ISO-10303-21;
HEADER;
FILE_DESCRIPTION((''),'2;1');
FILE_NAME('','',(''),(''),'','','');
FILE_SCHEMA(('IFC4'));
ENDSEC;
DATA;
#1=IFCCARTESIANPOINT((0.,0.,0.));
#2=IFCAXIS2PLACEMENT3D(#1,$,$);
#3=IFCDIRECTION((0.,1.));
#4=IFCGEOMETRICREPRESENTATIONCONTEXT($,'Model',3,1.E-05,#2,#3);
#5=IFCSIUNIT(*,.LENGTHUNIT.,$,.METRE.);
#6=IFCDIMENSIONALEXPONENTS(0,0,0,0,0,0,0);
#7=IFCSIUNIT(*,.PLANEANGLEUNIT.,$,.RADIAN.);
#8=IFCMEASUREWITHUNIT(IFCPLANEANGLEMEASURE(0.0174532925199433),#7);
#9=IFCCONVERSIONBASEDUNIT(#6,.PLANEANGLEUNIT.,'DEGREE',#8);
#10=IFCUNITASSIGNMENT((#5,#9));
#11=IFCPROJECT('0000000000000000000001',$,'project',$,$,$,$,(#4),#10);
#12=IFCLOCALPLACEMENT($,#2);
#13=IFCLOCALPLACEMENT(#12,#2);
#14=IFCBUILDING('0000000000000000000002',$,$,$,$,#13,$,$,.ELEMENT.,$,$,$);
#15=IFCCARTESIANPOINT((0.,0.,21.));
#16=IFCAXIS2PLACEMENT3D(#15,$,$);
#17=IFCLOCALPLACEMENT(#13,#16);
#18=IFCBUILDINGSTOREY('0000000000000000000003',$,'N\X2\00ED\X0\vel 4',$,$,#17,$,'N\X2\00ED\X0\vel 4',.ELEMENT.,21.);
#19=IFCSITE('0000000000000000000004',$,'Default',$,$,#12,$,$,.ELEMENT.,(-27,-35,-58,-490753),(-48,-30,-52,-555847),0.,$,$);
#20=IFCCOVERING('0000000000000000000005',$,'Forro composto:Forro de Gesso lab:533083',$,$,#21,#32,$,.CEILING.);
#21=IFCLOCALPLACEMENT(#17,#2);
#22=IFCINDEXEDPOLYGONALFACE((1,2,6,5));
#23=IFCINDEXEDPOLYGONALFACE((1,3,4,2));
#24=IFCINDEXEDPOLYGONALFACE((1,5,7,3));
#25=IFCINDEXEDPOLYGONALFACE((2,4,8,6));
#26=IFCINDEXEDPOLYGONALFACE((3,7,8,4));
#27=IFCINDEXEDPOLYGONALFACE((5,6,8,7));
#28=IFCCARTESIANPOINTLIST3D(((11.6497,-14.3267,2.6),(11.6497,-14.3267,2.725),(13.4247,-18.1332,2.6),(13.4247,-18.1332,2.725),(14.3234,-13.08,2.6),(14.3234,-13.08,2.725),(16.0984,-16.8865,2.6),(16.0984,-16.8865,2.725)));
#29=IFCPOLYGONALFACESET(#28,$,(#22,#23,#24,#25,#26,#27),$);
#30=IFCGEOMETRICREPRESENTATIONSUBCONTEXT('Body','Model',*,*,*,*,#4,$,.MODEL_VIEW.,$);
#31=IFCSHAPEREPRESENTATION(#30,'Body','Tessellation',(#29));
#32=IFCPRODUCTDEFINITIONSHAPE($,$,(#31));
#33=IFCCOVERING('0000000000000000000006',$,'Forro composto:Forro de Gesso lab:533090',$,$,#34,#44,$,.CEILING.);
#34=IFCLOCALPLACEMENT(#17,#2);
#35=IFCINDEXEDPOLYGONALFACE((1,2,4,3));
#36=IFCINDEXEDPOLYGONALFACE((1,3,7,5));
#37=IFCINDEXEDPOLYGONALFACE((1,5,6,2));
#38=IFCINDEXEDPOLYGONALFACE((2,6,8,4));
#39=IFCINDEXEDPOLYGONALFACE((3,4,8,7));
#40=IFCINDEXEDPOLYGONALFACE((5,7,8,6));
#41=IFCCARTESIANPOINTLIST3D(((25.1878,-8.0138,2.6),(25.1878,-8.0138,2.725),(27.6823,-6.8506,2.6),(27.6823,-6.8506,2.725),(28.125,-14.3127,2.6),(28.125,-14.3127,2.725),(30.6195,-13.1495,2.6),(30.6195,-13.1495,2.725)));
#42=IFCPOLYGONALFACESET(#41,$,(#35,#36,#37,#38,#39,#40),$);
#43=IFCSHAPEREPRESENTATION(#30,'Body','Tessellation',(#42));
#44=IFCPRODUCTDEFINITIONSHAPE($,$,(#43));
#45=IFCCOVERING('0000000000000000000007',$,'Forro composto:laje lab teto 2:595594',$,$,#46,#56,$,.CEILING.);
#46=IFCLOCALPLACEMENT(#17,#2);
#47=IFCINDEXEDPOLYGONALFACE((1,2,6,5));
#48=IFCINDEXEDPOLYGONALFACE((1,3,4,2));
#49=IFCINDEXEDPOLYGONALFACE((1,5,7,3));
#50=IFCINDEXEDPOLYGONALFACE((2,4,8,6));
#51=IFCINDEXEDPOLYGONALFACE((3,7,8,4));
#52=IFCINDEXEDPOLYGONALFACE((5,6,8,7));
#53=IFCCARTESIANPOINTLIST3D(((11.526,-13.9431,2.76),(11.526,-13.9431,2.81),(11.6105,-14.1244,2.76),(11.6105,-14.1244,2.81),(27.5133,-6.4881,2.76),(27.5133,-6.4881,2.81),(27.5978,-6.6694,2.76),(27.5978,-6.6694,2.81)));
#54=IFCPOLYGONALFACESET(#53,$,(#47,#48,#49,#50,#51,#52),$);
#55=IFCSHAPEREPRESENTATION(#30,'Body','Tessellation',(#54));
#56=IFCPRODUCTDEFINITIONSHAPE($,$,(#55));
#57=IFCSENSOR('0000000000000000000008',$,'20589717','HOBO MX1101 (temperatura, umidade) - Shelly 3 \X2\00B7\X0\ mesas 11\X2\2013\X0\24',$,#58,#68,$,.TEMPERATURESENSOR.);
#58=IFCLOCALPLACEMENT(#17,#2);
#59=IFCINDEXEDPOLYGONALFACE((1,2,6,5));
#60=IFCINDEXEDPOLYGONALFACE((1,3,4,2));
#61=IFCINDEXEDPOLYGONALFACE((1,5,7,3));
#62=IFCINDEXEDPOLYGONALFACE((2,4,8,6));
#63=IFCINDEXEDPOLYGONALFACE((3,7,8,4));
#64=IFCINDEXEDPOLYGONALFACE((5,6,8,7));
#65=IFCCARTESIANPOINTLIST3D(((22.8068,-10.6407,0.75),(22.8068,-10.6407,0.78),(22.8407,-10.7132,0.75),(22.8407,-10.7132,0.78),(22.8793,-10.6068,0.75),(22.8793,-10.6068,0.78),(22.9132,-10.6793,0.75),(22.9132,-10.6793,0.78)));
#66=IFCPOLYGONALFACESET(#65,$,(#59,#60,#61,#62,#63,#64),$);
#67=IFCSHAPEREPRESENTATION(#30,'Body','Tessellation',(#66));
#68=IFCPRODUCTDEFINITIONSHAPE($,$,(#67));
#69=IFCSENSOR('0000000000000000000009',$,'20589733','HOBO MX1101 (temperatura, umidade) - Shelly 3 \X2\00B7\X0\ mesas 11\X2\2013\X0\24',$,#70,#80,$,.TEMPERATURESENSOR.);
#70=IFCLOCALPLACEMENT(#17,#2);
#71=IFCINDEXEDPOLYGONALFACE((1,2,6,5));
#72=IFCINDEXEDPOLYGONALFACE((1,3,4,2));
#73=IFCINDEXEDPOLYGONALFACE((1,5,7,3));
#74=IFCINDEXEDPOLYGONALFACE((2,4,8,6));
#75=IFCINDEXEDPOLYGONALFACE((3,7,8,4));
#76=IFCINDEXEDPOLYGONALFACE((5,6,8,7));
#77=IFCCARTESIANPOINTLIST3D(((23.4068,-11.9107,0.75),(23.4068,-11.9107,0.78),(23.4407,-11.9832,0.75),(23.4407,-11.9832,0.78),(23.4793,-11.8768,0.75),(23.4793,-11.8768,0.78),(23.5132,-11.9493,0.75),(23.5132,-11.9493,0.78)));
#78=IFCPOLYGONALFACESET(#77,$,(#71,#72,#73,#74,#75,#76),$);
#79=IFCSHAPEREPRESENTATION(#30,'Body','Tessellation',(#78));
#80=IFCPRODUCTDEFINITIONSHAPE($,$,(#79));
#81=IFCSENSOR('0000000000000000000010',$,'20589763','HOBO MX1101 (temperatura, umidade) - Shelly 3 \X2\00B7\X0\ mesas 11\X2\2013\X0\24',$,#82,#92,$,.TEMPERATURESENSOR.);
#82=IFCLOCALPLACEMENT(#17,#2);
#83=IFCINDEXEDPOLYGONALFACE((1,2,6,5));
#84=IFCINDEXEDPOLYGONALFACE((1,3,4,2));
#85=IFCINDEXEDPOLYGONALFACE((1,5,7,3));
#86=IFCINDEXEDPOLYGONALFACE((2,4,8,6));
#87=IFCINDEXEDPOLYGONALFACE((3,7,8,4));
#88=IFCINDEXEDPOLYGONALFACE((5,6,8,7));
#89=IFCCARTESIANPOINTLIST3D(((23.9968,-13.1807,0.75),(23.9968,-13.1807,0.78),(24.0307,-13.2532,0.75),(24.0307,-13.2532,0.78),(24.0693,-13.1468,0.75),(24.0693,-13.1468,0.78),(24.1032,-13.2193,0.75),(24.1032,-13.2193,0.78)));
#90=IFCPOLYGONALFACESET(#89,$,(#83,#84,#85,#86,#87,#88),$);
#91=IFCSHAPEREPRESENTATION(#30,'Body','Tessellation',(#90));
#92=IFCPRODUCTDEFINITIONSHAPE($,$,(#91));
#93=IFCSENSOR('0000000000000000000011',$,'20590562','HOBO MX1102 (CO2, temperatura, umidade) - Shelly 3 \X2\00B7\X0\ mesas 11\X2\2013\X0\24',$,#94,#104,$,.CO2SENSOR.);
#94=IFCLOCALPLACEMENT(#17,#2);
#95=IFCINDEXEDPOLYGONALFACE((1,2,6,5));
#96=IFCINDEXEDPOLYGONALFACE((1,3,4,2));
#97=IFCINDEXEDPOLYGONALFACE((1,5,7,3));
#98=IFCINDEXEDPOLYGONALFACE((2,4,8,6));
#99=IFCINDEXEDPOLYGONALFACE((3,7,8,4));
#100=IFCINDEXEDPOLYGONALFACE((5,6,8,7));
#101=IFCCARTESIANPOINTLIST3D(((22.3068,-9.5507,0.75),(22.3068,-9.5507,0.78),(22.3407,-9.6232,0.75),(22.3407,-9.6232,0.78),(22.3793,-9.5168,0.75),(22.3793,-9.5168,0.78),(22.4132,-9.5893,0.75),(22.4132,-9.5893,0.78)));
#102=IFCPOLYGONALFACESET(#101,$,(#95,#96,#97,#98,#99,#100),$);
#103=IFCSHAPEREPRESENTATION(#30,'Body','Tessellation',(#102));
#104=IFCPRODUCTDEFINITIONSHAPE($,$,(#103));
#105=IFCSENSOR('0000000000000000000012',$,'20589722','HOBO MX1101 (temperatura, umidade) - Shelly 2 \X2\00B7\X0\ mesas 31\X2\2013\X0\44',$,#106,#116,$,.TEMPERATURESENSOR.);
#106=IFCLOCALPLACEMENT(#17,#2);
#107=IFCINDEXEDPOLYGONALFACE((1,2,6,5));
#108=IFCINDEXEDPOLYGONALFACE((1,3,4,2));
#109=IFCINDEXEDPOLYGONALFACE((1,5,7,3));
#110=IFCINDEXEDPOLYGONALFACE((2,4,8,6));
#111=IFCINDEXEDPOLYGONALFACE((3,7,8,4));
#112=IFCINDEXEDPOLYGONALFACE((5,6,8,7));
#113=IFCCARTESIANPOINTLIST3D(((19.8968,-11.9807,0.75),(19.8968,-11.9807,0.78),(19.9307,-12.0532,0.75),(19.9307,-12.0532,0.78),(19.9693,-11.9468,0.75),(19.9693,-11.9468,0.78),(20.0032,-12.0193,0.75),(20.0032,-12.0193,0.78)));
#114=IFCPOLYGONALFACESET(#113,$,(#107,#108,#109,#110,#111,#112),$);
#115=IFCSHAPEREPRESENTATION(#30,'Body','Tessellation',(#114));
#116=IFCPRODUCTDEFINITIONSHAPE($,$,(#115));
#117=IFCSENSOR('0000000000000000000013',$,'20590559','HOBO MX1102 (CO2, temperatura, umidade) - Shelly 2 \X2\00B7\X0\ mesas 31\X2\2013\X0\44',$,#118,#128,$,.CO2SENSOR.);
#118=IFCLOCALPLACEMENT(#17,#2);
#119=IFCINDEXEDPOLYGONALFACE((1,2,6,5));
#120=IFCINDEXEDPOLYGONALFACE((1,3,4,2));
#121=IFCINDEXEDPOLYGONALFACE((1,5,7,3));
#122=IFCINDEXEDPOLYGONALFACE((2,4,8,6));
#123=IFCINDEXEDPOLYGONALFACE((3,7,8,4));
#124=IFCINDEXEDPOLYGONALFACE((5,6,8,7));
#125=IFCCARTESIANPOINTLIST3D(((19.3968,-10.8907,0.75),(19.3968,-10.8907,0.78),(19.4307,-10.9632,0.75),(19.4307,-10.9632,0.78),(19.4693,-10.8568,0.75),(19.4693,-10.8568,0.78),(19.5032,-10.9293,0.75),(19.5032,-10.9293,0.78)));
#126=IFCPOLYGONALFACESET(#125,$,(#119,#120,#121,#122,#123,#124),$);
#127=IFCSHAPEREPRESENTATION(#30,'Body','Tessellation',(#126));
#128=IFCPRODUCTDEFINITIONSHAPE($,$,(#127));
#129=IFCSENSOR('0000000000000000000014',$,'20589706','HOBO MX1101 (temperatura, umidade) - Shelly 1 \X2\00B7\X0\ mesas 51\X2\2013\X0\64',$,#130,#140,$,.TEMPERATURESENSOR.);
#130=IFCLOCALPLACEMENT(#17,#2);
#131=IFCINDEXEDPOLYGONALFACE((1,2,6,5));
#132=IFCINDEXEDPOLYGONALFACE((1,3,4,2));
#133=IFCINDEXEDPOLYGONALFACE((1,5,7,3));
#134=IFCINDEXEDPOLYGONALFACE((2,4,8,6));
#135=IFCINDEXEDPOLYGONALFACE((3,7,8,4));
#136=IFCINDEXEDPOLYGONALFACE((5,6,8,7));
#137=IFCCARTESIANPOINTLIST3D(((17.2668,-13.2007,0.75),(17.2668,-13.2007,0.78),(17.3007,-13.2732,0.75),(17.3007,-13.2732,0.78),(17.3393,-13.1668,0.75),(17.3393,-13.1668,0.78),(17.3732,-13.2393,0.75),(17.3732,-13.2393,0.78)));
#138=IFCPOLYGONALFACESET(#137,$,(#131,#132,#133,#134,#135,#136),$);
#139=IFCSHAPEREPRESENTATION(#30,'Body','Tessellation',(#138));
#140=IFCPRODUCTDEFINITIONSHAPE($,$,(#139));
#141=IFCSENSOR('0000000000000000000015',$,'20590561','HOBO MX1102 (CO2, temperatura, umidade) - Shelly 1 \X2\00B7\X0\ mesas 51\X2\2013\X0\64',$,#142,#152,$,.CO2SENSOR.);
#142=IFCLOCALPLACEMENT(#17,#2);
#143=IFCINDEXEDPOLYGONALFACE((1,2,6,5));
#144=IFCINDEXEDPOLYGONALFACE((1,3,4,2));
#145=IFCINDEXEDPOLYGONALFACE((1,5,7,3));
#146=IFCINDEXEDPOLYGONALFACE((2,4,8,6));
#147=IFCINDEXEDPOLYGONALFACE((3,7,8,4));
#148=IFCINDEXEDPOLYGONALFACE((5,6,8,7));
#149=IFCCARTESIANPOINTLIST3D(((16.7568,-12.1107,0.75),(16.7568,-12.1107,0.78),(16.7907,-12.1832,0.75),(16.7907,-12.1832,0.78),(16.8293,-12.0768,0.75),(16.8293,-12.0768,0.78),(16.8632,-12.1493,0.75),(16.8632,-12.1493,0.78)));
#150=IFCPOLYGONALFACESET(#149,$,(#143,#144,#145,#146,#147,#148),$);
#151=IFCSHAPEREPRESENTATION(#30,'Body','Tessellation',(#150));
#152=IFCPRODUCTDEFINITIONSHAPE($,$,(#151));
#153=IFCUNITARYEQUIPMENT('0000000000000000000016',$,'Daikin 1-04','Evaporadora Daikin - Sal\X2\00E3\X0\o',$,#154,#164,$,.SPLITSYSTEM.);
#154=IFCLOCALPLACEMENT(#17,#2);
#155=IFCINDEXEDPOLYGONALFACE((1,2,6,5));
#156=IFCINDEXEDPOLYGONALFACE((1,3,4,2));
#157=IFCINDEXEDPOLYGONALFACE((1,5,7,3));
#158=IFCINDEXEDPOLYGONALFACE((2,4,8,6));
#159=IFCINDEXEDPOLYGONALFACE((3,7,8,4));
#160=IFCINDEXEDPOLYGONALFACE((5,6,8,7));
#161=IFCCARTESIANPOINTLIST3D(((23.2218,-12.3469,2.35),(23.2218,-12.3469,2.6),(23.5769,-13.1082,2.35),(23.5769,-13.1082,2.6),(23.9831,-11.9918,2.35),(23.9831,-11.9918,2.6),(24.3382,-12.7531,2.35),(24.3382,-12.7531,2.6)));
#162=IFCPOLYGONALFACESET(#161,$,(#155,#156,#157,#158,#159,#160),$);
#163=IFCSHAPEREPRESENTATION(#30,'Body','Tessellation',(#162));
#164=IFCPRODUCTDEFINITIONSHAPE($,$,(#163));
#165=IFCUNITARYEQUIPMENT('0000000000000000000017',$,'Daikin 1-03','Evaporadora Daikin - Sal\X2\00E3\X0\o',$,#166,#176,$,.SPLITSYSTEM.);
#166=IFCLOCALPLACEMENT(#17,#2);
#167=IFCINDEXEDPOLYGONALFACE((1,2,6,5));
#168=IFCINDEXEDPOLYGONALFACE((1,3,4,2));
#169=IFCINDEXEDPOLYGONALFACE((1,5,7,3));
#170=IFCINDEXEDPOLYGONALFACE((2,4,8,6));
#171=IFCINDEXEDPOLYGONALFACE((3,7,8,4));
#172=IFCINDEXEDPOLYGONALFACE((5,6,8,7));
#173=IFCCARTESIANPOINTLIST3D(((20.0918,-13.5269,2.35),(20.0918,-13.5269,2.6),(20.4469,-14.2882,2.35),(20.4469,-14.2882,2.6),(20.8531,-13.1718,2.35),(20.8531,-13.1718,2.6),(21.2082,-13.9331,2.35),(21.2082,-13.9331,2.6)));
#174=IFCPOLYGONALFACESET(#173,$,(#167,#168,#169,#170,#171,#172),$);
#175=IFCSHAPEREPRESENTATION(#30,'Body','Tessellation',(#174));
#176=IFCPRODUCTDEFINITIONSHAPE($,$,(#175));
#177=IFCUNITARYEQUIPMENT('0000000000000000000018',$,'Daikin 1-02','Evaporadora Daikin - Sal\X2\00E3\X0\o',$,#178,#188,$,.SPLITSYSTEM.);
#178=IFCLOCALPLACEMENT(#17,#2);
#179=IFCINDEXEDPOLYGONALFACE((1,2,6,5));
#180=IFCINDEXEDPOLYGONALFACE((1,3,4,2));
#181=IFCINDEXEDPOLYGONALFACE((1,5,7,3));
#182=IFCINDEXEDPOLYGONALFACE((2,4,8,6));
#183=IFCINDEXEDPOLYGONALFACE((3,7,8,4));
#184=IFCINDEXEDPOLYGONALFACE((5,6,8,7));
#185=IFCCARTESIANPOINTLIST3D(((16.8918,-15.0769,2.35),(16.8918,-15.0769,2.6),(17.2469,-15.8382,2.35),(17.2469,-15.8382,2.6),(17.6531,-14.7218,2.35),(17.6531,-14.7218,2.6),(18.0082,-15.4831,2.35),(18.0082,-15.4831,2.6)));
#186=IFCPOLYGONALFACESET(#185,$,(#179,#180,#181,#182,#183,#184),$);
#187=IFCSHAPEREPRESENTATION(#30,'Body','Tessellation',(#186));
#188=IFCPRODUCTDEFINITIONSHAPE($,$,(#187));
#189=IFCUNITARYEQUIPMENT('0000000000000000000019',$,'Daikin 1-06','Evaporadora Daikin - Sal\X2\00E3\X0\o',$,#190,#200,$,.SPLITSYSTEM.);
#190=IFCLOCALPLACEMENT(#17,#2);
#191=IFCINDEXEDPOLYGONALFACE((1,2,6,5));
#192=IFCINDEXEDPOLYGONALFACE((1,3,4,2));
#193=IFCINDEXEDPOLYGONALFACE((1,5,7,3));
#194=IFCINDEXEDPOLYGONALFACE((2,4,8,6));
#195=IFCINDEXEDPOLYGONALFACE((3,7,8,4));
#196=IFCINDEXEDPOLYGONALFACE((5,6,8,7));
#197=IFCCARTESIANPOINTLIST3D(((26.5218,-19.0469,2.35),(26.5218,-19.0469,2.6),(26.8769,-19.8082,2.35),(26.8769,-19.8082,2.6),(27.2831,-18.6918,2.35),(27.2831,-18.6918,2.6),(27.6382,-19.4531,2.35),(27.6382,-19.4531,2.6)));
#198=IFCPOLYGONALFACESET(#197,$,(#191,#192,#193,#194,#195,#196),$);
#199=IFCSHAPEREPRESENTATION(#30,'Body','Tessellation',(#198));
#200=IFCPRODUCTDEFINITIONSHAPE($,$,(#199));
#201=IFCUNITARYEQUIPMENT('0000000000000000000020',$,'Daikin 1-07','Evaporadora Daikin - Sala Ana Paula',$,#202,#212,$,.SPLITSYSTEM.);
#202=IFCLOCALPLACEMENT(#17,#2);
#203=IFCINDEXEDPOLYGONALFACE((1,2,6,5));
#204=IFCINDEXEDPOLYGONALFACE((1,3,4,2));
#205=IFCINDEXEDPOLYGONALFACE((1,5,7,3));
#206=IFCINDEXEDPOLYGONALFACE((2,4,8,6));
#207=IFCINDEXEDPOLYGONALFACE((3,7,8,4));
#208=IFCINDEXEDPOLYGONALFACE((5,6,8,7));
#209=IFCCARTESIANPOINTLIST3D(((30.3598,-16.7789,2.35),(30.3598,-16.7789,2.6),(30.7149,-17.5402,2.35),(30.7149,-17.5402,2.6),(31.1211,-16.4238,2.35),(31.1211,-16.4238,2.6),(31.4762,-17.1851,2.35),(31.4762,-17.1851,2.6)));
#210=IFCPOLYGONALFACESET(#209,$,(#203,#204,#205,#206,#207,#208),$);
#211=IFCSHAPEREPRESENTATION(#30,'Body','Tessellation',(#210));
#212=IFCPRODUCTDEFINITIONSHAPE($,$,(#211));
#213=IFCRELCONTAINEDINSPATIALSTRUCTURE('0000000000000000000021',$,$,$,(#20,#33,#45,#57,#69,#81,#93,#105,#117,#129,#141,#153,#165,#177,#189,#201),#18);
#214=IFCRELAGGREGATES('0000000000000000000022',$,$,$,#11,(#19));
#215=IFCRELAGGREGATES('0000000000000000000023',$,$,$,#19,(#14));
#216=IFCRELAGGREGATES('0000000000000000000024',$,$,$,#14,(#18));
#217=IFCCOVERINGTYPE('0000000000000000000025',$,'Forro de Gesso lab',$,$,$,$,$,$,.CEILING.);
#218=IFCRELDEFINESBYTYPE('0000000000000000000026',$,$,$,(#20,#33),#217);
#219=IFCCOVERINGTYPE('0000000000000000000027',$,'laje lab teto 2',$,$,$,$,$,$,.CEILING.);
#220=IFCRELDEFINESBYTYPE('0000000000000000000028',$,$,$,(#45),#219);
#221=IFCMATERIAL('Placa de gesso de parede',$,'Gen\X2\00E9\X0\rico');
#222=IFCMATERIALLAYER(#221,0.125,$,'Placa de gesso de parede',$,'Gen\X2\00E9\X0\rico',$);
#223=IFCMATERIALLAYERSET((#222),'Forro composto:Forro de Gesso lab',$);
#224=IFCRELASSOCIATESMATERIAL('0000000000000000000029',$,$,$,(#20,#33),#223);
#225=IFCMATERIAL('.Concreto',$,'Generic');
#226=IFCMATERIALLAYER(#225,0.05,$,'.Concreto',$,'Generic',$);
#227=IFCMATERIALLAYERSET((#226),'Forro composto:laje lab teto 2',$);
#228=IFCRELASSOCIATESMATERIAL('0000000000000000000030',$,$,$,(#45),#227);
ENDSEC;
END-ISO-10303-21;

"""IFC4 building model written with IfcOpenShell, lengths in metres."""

from ifc_helpers import new_model, entity, si_unit, converted_unit, direction, frame, frame_2d, origin, origin_2d, place, context, subcontext, project, spatial, rectangle, extrude, material, layer, layer_set, layer_usage, type_object, element, save


model = new_model("IFC4")

# Units and contexts
model_context = context("Model", 3, precision=1e-05, world=origin(), true_north=direction((0.0, 1.0)))
body_context = subcontext(model_context, "Body", "Model", "MODEL_VIEW")
ifc_project = project(units=[si_unit("LENGTHUNIT", "METRE"), converted_unit("PLANEANGLEUNIT", "DEGREE", entity("IfcPlaneAngleMeasure", 0.0174532925199433), si_unit("PLANEANGLEUNIT", "RADIAN"), dimensions=[0, 0, 0, 0, 0, 0, 0])], contexts=[model_context])

# Site, building, storey
site_placement = place(None, origin())
site = spatial("IfcSite", under=ifc_project, at=site_placement, Name="Default", CompositionType="ELEMENT", RefLatitude=(-27, -35, -58, -490753), RefLongitude=(-48, -30, -52, -555847), RefElevation=0.0)
building_placement = place(site_placement, origin())
building = spatial("IfcBuilding", under=site, at=building_placement, CompositionType="ELEMENT")
storey_placement = place(building_placement, frame((0.0, 0.0, 21.0)))
storey = spatial("IfcBuildingStorey", under=building, at=storey_placement, Name="Nível 4", LongName="Nível 4", CompositionType="ELEMENT", Elevation=21.0)

# Coverings
ifc_material_1 = material(Name="Placa de gesso de parede", Category="Genérico")
ifc_layer_1 = layer(ifc_material_1, 0.125, Name="Placa de gesso de parede", Category="Genérico")
ifc_layer_set_1 = layer_set([ifc_layer_1], Name="Forro composto:Forro de Gesso lab")
ifc_layer_usage_1 = layer_usage(ifc_layer_set_1, "AXIS3", "NEGATIVE", 0.125)
covering_type_1 = type_object("IfcCoveringType", Name="Forro de Gesso lab", PredefinedType="CEILING")
covering_1_placement = place(storey_placement, frame((11.6497, -18.1332, 2.6), z_axis=(0.0, 0.0, 1.0), x_axis=(1.0, 0.0, 0.0)))
element("IfcCovering", 1, at=covering_1_placement, inside=storey, type_object=covering_type_1, material=ifc_layer_usage_1, Name="Forro composto:Forro de Gesso lab:533083", PredefinedType="CEILING", context=body_context, shape_type="SweptSolid", body=[
    extrude(rectangle(XDim=2.95, YDim=4.2, at=frame_2d((0.0, 0.0), x_axis=(1.0, 0.0))), frame((2.2243, 2.5266, 0.0), z_axis=(0.0, 0.0, 1.0), x_axis=(0.906308, 0.422618, 0.0)), (0.0, 0.0, 1.0), 0.125),
])
ifc_layer_usage_2 = layer_usage(ifc_layer_set_1, "AXIS3", "NEGATIVE", 0.0)
covering_2_placement = place(storey_placement, frame((25.1878, -14.3127, 2.6), z_axis=(0.0, 0.0, 1.0), x_axis=(1.0, 0.0, 0.0)))
element("IfcCovering", 2, at=covering_2_placement, inside=storey, type_object=covering_type_1, material=ifc_layer_usage_2, Name="Forro composto:Forro de Gesso lab:533090", PredefinedType="CEILING", context=body_context, shape_type="SweptSolid", body=[
    extrude(rectangle(XDim=6.95, YDim=2.7524, at=frame_2d((0.0, 0.0), x_axis=(1.0, 0.0))), frame((2.7159, 3.731, 0.0), z_axis=(0.0, 0.0, 1.0), x_axis=(0.422618, -0.906308, 0.0)), (0.0, 0.0, 1.0), 0.125),
])
ifc_material_2 = material(Name=".Concreto", Category="Generic")
ifc_layer_2 = layer(ifc_material_2, 0.05, Name=".Concreto", Category="Generic")
ifc_layer_set_2 = layer_set([ifc_layer_2], Name="Forro composto:laje lab teto 2")
ifc_layer_usage_3 = layer_usage(ifc_layer_set_2, "AXIS3", "NEGATIVE", 0.05)
covering_type_2 = type_object("IfcCoveringType", Name="laje lab teto 2", PredefinedType="CEILING")
covering_3_placement = place(storey_placement, frame((11.526, -14.1244, 2.76), z_axis=(0.0, 0.0, 1.0), x_axis=(1.0, 0.0, 0.0)))
element("IfcCovering", 3, at=covering_3_placement, inside=storey, type_object=covering_type_2, material=ifc_layer_usage_3, Name="Forro composto:laje lab teto 2:595594", PredefinedType="CEILING", context=body_context, shape_type="SweptSolid", body=[
    extrude(rectangle(XDim=0.2, YDim=17.64, at=frame_2d((0.0, 0.0), x_axis=(1.0, 0.0))), frame((8.0359, 3.8181, 0.0), z_axis=(0.0, 0.0, 1.0), x_axis=(0.422618, -0.906308, 0.0)), (0.0, 0.0, 1.0), 0.05),
])

# Sensors
for number, where, z_axis, x_axis, name in (
    (4, (22.86, -10.66, 21.75), (0.0, 0.0, 1.0), (0.906245, 0.422754, 0.0), "20589717"),
    (5, (23.46, -11.93, 21.75), (0.0, 0.0, 1.0), (0.906245, 0.422754, 0.0), "20589733"),
    (6, (24.05, -13.2, 21.75), (0.0, 0.0, 1.0), (0.906245, 0.422754, 0.0), "20589763"),
):
    element("IfcSensor", number, at=place(None, frame(where, z_axis=z_axis, x_axis=x_axis)), inside=storey, Name=name, Description="HOBO MX1101 (temperatura, umidade) - Shelly 3 · mesas 11–24", PredefinedType="TEMPERATURESENSOR", context=body_context, shape_type="SweptSolid", body=[
        extrude(rectangle(XDim=0.08, YDim=0.08, at=origin_2d()), None, (0.0, 0.0, 1.0), 0.03),
    ])
sensor_1_placement = place(None, frame((22.36, -9.57, 21.75), z_axis=(0.0, 0.0, 1.0), x_axis=(0.906245, 0.422754, 0.0)))
element("IfcSensor", 7, at=sensor_1_placement, inside=storey, Name="20590562", Description="HOBO MX1102 (CO2, temperatura, umidade) - Shelly 3 · mesas 11–24", PredefinedType="CO2SENSOR", context=body_context, shape_type="SweptSolid", body=[
    extrude(rectangle(XDim=0.08, YDim=0.08, at=origin_2d()), None, (0.0, 0.0, 1.0), 0.03),
])
sensor_2_placement = place(None, frame((19.95, -12.0, 21.75), z_axis=(0.0, 0.0, 1.0), x_axis=(0.906245, 0.422754, 0.0)))
element("IfcSensor", 8, at=sensor_2_placement, inside=storey, Name="20589722", Description="HOBO MX1101 (temperatura, umidade) - Shelly 2 · mesas 31–44", PredefinedType="TEMPERATURESENSOR", context=body_context, shape_type="SweptSolid", body=[
    extrude(rectangle(XDim=0.08, YDim=0.08, at=origin_2d()), None, (0.0, 0.0, 1.0), 0.03),
])
sensor_3_placement = place(None, frame((19.45, -10.91, 21.75), z_axis=(0.0, 0.0, 1.0), x_axis=(0.906245, 0.422754, 0.0)))
element("IfcSensor", 9, at=sensor_3_placement, inside=storey, Name="20590559", Description="HOBO MX1102 (CO2, temperatura, umidade) - Shelly 2 · mesas 31–44", PredefinedType="CO2SENSOR", context=body_context, shape_type="SweptSolid", body=[
    extrude(rectangle(XDim=0.08, YDim=0.08, at=origin_2d()), None, (0.0, 0.0, 1.0), 0.03),
])
sensor_4_placement = place(None, frame((17.32, -13.22, 21.75), z_axis=(0.0, 0.0, 1.0), x_axis=(0.906245, 0.422754, 0.0)))
element("IfcSensor", 10, at=sensor_4_placement, inside=storey, Name="20589706", Description="HOBO MX1101 (temperatura, umidade) - Shelly 1 · mesas 51–64", PredefinedType="TEMPERATURESENSOR", context=body_context, shape_type="SweptSolid", body=[
    extrude(rectangle(XDim=0.08, YDim=0.08, at=origin_2d()), None, (0.0, 0.0, 1.0), 0.03),
])
sensor_5_placement = place(None, frame((16.81, -12.13, 21.75), z_axis=(0.0, 0.0, 1.0), x_axis=(0.906245, 0.422754, 0.0)))
element("IfcSensor", 11, at=sensor_5_placement, inside=storey, Name="20590561", Description="HOBO MX1102 (CO2, temperatura, umidade) - Shelly 1 · mesas 51–64", PredefinedType="CO2SENSOR", context=body_context, shape_type="SweptSolid", body=[
    extrude(rectangle(XDim=0.08, YDim=0.08, at=origin_2d()), None, (0.0, 0.0, 1.0), 0.03),
])

# Unitary equipment
for number, where, z_axis, x_axis, name, description in (
    (12, (23.78, -12.55, 23.35), (0.0, 0.0, 1.0), (0.906245, 0.422754, 0.0), "Daikin 1-04", "Evaporadora Daikin - Salão"),
    (13, (20.65, -13.73, 23.35), (0.0, 0.0, 1.0), (0.906245, 0.422754, 0.0), "Daikin 1-03", "Evaporadora Daikin - Salão"),
    (14, (17.45, -15.28, 23.35), (0.0, 0.0, 1.0), (0.906245, 0.422754, 0.0), "Daikin 1-02", "Evaporadora Daikin - Salão"),
    (15, (27.08, -19.25, 23.35), (0.0, 0.0, 1.0), (0.906245, 0.422754, 0.0), "Daikin 1-06", "Evaporadora Daikin - Salão"),
    (16, (30.918, -16.982, 23.35), (0.0, 0.0, 1.0), (0.906245, 0.422754, 0.0), "Daikin 1-07", "Evaporadora Daikin - Sala Ana Paula"),
):
    element("IfcUnitaryEquipment", number, at=place(None, frame(where, z_axis=z_axis, x_axis=x_axis)), inside=storey, Name=name, Description=description, PredefinedType="SPLITSYSTEM", context=body_context, shape_type="SweptSolid", body=[
        extrude(rectangle(XDim=0.84, YDim=0.84, at=origin_2d()), None, (0.0, 0.0, 1.0), 0.25),
    ])

save(model, "model.ifc")
